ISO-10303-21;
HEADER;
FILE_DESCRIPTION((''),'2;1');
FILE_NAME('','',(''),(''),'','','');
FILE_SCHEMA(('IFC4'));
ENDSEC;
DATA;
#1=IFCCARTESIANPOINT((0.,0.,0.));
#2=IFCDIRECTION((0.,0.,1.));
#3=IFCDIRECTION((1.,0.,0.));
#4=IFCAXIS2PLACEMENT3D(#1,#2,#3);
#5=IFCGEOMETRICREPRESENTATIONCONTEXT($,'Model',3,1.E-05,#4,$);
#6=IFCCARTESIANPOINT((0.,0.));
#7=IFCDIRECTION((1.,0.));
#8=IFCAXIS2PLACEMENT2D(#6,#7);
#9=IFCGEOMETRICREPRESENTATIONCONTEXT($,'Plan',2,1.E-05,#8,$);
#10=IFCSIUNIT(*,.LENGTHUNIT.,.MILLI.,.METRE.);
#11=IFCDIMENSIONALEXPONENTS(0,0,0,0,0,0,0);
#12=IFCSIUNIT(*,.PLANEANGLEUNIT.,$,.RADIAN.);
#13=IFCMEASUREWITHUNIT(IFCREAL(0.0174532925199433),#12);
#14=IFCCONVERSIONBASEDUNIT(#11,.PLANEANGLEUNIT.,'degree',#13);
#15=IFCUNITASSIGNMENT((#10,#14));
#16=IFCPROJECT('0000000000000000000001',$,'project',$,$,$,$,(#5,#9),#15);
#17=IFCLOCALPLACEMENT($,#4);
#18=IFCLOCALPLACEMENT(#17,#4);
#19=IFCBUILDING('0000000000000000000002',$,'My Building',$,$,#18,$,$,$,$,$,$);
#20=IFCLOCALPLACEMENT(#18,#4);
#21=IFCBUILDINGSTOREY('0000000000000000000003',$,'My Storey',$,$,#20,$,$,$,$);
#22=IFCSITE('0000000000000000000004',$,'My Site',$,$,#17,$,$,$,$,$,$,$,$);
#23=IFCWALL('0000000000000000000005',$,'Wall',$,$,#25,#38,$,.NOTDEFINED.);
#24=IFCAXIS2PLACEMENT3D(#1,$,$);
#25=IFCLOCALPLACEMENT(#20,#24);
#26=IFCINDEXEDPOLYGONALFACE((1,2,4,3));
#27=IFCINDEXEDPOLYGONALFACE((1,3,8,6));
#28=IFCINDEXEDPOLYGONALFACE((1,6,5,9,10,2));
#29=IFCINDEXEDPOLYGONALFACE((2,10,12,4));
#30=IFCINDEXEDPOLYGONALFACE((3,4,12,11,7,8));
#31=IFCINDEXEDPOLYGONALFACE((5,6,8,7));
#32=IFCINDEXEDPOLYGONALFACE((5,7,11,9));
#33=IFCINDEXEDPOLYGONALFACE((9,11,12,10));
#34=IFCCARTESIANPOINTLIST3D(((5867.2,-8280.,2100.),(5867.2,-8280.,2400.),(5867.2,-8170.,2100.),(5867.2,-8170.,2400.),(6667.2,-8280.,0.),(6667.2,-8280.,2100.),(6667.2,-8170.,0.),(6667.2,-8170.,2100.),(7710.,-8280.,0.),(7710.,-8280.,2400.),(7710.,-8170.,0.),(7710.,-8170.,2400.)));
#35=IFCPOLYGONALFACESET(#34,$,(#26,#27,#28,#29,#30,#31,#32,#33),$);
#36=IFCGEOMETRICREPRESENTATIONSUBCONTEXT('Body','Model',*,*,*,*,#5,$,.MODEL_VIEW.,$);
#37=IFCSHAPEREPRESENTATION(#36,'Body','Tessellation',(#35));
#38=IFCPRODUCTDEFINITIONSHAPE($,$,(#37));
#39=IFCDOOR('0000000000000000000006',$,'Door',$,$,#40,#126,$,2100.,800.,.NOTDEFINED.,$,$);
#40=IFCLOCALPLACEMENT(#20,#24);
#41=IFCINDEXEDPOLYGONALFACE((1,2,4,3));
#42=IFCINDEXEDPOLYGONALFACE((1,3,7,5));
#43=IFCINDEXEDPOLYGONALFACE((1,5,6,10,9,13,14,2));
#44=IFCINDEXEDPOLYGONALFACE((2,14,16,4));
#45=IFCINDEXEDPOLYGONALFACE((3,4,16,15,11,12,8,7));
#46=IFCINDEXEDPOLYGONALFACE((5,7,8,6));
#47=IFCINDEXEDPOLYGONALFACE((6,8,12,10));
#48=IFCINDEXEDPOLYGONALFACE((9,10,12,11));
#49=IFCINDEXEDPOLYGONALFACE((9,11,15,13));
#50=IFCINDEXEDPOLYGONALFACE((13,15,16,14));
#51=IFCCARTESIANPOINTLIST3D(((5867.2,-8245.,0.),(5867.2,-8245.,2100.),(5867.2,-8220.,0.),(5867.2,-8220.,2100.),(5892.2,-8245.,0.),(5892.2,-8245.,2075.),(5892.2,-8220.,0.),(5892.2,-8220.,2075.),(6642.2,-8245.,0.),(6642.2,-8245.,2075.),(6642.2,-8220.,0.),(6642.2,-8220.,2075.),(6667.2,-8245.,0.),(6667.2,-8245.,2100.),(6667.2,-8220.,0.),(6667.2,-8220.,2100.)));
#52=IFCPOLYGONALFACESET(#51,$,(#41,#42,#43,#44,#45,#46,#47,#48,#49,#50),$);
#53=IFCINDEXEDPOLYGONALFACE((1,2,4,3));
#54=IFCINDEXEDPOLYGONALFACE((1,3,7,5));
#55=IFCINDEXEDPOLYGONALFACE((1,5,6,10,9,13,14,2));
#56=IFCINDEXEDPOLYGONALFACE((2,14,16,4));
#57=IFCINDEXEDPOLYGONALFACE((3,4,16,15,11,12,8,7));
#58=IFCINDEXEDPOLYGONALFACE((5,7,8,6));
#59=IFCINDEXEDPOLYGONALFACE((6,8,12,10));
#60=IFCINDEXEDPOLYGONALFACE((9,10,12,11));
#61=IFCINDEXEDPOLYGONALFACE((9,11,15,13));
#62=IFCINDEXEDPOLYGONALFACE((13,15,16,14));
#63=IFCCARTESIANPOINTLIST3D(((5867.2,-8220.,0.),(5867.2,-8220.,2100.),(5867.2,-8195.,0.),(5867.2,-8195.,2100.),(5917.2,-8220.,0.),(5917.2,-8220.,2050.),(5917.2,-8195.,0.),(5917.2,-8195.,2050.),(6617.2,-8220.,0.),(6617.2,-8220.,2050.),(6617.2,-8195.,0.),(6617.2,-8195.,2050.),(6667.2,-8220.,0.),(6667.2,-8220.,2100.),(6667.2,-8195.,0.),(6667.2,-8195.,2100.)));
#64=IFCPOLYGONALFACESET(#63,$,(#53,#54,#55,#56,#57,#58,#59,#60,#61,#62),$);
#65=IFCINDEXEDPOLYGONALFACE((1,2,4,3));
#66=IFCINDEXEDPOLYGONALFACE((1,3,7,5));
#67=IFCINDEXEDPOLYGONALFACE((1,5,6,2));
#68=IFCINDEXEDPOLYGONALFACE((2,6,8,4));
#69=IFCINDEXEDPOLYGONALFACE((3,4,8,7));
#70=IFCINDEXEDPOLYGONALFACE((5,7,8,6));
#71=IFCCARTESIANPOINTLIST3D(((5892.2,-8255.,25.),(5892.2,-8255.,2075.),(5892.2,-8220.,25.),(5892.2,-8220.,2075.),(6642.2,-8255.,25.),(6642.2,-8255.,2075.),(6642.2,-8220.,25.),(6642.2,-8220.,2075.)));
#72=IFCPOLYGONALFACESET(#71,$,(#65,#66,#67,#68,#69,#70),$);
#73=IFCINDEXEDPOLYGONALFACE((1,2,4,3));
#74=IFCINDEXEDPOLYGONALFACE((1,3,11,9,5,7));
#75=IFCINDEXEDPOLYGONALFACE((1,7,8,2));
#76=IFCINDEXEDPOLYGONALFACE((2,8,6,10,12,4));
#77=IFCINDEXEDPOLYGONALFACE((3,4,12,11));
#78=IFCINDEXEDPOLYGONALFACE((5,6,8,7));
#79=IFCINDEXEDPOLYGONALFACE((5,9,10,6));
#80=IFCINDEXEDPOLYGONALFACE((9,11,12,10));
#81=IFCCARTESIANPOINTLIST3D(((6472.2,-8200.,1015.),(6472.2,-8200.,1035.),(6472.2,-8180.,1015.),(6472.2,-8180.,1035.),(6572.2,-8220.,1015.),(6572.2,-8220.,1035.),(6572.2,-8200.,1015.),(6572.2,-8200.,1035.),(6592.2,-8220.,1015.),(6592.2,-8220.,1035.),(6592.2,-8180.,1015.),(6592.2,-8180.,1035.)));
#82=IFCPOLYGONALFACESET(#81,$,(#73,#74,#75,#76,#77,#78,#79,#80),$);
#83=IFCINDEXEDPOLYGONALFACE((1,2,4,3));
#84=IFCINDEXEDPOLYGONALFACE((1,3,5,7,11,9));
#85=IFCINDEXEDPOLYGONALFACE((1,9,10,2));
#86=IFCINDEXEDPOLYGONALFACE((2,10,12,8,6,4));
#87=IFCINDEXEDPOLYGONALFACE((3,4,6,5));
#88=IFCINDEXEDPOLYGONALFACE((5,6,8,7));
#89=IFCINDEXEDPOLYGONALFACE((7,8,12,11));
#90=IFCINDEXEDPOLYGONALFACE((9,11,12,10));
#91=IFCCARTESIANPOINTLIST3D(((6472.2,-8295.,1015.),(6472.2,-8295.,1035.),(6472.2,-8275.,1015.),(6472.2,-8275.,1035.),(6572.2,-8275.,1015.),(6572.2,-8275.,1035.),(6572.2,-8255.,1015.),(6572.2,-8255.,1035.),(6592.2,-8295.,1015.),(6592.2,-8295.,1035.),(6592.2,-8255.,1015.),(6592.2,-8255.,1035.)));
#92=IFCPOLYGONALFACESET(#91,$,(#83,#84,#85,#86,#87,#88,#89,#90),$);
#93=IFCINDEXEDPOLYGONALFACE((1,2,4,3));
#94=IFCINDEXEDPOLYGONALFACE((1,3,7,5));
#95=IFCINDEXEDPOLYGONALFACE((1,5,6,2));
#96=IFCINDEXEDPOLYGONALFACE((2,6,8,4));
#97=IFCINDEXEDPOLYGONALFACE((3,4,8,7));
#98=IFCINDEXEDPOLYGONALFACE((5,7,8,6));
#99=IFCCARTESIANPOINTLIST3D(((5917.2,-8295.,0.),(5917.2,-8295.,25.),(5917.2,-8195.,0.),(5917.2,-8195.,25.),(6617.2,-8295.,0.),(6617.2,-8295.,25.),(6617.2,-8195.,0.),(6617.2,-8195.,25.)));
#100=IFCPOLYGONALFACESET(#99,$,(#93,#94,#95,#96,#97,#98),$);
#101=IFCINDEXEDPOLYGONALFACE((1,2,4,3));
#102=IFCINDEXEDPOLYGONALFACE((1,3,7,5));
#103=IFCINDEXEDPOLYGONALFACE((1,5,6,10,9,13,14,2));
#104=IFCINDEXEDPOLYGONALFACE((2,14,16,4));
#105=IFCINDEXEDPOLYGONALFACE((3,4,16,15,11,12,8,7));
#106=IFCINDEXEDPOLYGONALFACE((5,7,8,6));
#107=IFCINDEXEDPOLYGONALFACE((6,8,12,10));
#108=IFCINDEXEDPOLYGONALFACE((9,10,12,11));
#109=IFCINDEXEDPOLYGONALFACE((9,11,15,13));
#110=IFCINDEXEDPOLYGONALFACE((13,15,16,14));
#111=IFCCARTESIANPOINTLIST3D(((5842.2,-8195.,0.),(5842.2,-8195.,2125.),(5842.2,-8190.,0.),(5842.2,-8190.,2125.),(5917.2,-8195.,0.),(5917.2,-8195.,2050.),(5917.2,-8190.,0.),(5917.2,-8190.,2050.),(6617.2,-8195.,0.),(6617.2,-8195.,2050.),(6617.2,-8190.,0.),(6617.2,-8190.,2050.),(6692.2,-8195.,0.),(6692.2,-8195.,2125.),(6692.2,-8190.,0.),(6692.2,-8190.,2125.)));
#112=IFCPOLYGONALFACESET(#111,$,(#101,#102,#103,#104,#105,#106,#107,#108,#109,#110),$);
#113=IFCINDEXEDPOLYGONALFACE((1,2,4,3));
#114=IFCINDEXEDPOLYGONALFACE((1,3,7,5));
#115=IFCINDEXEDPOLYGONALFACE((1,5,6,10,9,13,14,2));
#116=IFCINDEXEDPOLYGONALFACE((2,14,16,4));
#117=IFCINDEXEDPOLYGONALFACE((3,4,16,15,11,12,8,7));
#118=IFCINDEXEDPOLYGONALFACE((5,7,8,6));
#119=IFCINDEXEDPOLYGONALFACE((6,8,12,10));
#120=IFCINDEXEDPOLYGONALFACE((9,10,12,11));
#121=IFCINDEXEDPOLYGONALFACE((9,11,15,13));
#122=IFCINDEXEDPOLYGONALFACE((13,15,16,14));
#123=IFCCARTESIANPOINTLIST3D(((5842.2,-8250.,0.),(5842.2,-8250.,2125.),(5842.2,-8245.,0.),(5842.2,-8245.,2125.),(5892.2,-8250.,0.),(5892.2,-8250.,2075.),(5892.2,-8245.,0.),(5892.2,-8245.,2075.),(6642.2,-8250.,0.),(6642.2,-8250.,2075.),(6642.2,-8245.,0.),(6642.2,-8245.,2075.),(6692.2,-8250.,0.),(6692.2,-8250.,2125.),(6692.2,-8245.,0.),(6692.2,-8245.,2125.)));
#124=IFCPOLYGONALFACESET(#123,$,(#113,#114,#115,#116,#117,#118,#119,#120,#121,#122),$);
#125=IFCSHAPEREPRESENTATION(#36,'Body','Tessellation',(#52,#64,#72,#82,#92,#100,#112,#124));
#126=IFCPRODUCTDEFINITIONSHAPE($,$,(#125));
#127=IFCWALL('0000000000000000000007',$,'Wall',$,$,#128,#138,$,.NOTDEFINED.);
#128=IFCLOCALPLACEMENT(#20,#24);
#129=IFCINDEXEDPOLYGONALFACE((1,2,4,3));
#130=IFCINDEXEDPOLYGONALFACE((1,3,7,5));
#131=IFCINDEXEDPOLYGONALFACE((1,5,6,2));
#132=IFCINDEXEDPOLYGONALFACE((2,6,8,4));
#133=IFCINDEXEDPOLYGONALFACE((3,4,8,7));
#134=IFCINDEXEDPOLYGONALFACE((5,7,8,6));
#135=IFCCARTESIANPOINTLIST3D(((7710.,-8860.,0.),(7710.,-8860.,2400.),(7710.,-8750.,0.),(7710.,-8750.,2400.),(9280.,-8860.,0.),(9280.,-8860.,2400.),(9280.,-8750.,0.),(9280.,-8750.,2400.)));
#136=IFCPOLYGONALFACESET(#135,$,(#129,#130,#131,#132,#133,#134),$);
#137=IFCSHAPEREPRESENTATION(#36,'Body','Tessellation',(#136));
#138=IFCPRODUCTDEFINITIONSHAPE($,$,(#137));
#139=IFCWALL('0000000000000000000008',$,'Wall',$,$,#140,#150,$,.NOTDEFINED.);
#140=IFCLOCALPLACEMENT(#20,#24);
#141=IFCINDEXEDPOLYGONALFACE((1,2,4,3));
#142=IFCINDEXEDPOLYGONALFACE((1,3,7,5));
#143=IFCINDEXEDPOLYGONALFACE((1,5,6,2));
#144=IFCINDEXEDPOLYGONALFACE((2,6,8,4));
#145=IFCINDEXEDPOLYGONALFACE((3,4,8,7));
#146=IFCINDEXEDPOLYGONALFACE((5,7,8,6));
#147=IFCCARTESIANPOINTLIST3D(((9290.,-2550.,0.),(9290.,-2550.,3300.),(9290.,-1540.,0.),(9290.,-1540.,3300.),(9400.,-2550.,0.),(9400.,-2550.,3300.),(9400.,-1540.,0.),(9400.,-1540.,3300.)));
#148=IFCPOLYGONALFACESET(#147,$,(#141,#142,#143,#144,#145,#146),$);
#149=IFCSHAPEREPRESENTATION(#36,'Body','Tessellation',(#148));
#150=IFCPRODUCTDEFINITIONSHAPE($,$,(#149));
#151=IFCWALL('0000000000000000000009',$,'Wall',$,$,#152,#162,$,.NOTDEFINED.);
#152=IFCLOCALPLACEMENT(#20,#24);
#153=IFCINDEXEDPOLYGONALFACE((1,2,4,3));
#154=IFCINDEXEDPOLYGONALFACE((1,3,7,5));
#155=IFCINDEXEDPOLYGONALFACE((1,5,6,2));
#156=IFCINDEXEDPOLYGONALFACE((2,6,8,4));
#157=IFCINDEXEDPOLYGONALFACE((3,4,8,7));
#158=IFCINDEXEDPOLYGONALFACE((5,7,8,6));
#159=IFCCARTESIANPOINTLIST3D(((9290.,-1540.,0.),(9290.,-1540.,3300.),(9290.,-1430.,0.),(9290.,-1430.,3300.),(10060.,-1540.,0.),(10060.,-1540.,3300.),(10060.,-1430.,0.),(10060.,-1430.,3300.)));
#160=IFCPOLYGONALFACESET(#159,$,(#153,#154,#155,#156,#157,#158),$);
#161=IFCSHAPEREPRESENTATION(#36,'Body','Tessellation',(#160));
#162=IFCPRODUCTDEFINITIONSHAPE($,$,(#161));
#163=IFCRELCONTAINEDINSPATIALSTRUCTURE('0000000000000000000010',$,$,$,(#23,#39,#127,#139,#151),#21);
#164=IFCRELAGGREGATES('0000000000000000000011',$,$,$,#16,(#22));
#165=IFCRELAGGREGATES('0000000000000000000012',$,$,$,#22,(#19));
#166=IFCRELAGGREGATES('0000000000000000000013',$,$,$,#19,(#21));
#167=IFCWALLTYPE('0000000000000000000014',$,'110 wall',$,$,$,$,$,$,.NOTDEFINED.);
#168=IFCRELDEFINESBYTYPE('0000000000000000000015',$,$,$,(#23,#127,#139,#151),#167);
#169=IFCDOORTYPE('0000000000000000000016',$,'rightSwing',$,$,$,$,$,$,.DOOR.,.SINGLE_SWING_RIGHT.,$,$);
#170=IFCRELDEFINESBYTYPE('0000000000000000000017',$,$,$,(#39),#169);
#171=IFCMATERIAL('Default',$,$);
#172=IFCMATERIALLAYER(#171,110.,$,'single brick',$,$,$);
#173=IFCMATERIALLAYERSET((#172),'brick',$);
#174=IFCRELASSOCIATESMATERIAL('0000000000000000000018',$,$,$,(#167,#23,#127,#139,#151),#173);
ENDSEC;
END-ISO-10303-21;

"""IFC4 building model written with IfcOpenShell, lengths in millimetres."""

from ifc_helpers import new_model, entity, si_unit, converted_unit, frame, origin_with_axes, origin_2d_with_axis, place, context, subcontext, project, spatial, line, indexed_curve, outline, extrude, shape, source, transform, mapped, material, layer, layer_set, layer_usage, type_object, type_shapes, element, fill, save


model = new_model("IFC4")

# Units and contexts
model_context = context("Model", 3, precision=1e-05, world=origin_with_axes())
plan_context = context("Plan", 2, precision=1e-05, world=origin_2d_with_axis())
body_context_1 = subcontext(model_context, "Body", "Model", "MODEL_VIEW")
body_context_2 = subcontext(plan_context, "Body", "Plan", "PLAN_VIEW")
ifc_project = project(units=[si_unit("LENGTHUNIT", "METRE", prefix="MILLI"), converted_unit("PLANEANGLEUNIT", "degree", entity("IfcReal", 0.0174532925199433), si_unit("PLANEANGLEUNIT", "RADIAN"), dimensions=[0, 0, 0, 0, 0, 0, 0])], contexts=[model_context, plan_context])

# Site, building, storey
site_placement = place(None, origin_with_axes())
site = spatial("IfcSite", under=ifc_project, at=site_placement, Name="My Site")
building_placement = place(site_placement, origin_with_axes())
building = spatial("IfcBuilding", under=site, at=building_placement, Name="My Building")
storey_placement = place(building_placement, origin_with_axes())
storey = spatial("IfcBuildingStorey", under=building, at=storey_placement, Name="My Storey")

# Shared definitions
ifc_material_1 = material(Name="Default")
ifc_layer_1 = layer(ifc_material_1, 110.0, Name="single brick")
ifc_layer_set_1 = layer_set([ifc_layer_1], Name="brick")
wall_type_1 = type_object("IfcWallType", Name="110 wall", PredefinedType="NOTDEFINED", material=ifc_layer_set_1)

# Wall, opening, door
ifc_layer_usage_1 = layer_usage(ifc_layer_set_1, "AXIS2", "POSITIVE", 0.0)
wall_1_placement = place(storey_placement, frame((5867.2, -8280.0, 0.0), z_axis=(0.0, 0.0, 1.0), x_axis=(1.0, -0.000001, 0.0)))
wall_1 = element("IfcWall", 1, at=wall_1_placement, inside=storey, type_object=wall_type_1, material=ifc_layer_usage_1, Name="Wall", PredefinedType="NOTDEFINED", context=body_context_1, shape_type="SweptSolid", body=[
    extrude(outline(indexed_curve([(0.0, 0.0), (0.0, 110.0), (1842.8, 110.0), (1842.8, 0.0), (0.0, 0.0)], self_intersect=False)), origin_with_axes(), (0.0, 0.0, 1.0), 2400.0),
])
shared_shape_1 = source(origin_with_axes(), body_context_1, "Body", "SweptSolid", [
    extrude(outline(indexed_curve([(0.0, 0.0, 0.0), (800.0, 0.0, 0.0), (800.0, 0.0, 2100.0), (0.0, 0.0, 2100.0)], segments=[line(1, 2), line(2, 3), line(3, 4), line(4, 1)])), frame((0.0, -100.0, 0.0), z_axis=(0.0, 0.0, 1.0), x_axis=(1.0, 0.0, 0.0)), (0.0, 1.0, 0.0), 310.0),
])
opening_1_placement = place(wall_1_placement, frame((800.0, 85.0, 0.0), z_axis=(0.0, 0.0, 1.0), x_axis=(-1.0, 0.0, 0.0)))
opening_1 = element("IfcOpeningElement", 2, at=opening_1_placement, cuts=wall_1, PredefinedType="OPENING", context=body_context_1, shape_type="MappedRepresentation", body=[
    mapped(shared_shape_1, transform((0.0, 0.0, 0.0), x_axis=(1.0, 0.0, 0.0), y_axis=(0.0, 1.0, 0.0), z_axis=(0.0, 0.0, 1.0), scale=1.0)),
])
door_type_1 = type_object("IfcDoorType", Name="rightSwing", OperationType="SINGLE_SWING_RIGHT", PredefinedType="DOOR")
shared_shape_2 = source(origin_with_axes(), body_context_1, "Body", "SweptSolid", [
    extrude(outline(indexed_curve([(0.0, 0.0, 0.0), (0.0, 0.0, 2100.0), (800.0, 0.0, 2100.0), (800.0, 0.0, 0.0), (775.0, 0.0, 0.0), (775.0, 0.0, 2075.0), (25.0, 0.0, 2075.0), (25.0, 0.0, 0.0)], segments=[line(1, 2), line(2, 3), line(3, 4), line(4, 5), line(5, 6), line(6, 7), line(7, 8), line(8, 1)])), frame((0.0, 25.0, 0.0), z_axis=(0.0, 0.0, 1.0), x_axis=(1.0, 0.0, 0.0)), (0.0, 1.0, 0.0), 25.0),
    extrude(outline(indexed_curve([(0.0, 0.0, 0.0), (0.0, 0.0, 2100.0), (800.0, 0.0, 2100.0), (800.0, 0.0, 0.0), (750.0, 0.0, 0.0), (750.0, 0.0, 2050.0), (50.0, 0.0, 2050.0), (50.0, 0.0, 0.0)], segments=[line(1, 2), line(2, 3), line(3, 4), line(4, 5), line(5, 6), line(6, 7), line(7, 8), line(8, 1)])), origin_with_axes(), (0.0, 1.0, 0.0), 25.0),
    extrude(outline(indexed_curve([(0.0, 0.0), (750.0, 0.0), (750.0, 35.0), (0.0, 35.0)], segments=[line(1, 2), line(2, 3), line(3, 4), line(4, 1)])), frame((25.0, 25.0, 25.0), z_axis=(0.0, 0.0, 1.0), x_axis=(1.0, 0.0, 0.0)), (0.0, 0.0, 1.0), 2050.0),
    extrude(outline(indexed_curve([(0.0, 0.0), (0.0, -40.0), (120.0, -40.0), (120.0, -20.0), (20.0, -20.0), (20.0, 0.0)], segments=[line(1, 2), line(2, 3), line(3, 4), line(4, 5), line(5, 6), line(6, 1)])), frame((75.0, 25.0, 1015.0), z_axis=(0.0, 0.0, 1.0), x_axis=(1.0, 0.0, 0.0)), (0.0, 0.0, 1.0), 20.0),
    extrude(outline(indexed_curve([(0.0, 0.0), (0.0, 40.0), (120.0, 40.0), (120.0, 20.0), (20.0, 20.0), (20.0, 0.0)], segments=[line(1, 2), line(2, 3), line(3, 4), line(4, 5), line(5, 6), line(6, 1)])), frame((75.0, 60.0, 1015.0), z_axis=(0.0, 0.0, 1.0), x_axis=(1.0, 0.0, 0.0)), (0.0, 0.0, 1.0), 20.0),
    extrude(outline(indexed_curve([(0.0, 0.0), (700.0, 0.0), (700.0, 100.0), (0.0, 100.0)], segments=[line(1, 2), line(2, 3), line(3, 4), line(4, 1)])), frame((50.0, 0.0, 0.0), z_axis=(0.0, 0.0, 1.0), x_axis=(1.0, 0.0, 0.0)), (0.0, 0.0, 1.0), 25.0),
    extrude(outline(indexed_curve([(0.0, 0.0, 0.0), (0.0, 0.0, 2125.0), (850.0, 0.0, 2125.0), (850.0, 0.0, 0.0), (775.0, 0.0, 0.0), (775.0, 0.0, 2050.0), (75.0, 0.0, 2050.0), (75.0, 0.0, 0.0)], segments=[line(1, 2), line(2, 3), line(3, 4), line(4, 5), line(5, 6), line(6, 7), line(7, 8), line(8, 1)])), frame((-25.0, -5.0, 0.0), z_axis=(0.0, 0.0, 1.0), x_axis=(1.0, 0.0, 0.0)), (0.0, 1.0, 0.0), 5.0),
    extrude(outline(indexed_curve([(0.0, 0.0, 0.0), (0.0, 0.0, 2125.0), (850.0, 0.0, 2125.0), (850.0, 0.0, 0.0), (800.0, 0.0, 0.0), (800.0, 0.0, 2075.0), (50.0, 0.0, 2075.0), (50.0, 0.0, 0.0)], segments=[line(1, 2), line(2, 3), line(3, 4), line(4, 5), line(5, 6), line(6, 7), line(7, 8), line(8, 1)])), frame((-25.0, 50.0, 0.0), z_axis=(0.0, 0.0, 1.0), x_axis=(1.0, 0.0, 0.0)), (0.0, 1.0, 0.0), 5.0),
])
shared_shape_3 = source(origin_with_axes(), body_context_2, "Body", "Curve2D", [
    entity("IfcIndexedPolyCurve", entity("IfcCartesianPointList2D", [[0.0, 0.0], [0.0, 50.0], [25.0, 50.0], [25.0, 25.0], [50.0, 25.0], [50.0, 0.0]]), [entity("IfcLineIndex", [1, 2]), entity("IfcLineIndex", [2, 3]), entity("IfcLineIndex", [3, 4]), entity("IfcLineIndex", [4, 5]), entity("IfcLineIndex", [5, 6]), entity("IfcLineIndex", [6, 1])]),
    entity("IfcIndexedPolyCurve", entity("IfcCartesianPointList2D", [[800.0, 0.0], [800.0, 50.0], [775.0, 50.0], [775.0, 25.0], [750.0, 25.0], [750.0, 0.0]]), [entity("IfcLineIndex", [1, 2]), entity("IfcLineIndex", [2, 3]), entity("IfcLineIndex", [3, 4]), entity("IfcLineIndex", [4, 5]), entity("IfcLineIndex", [5, 6]), entity("IfcLineIndex", [6, 1])]),
    entity("IfcTrimmedCurve", entity("IfcEllipse", entity("IfcAxis2Placement2D", entity("IfcCartesianPoint", [740.0, 50.0]), entity("IfcDirection", [1.0, 0.0])), 715.0, 750.0), [entity("IfcCartesianPoint", [740.0, 800.0])], [entity("IfcCartesianPoint", [25.0, 50.0])], True, "CARTESIAN"),
    entity("IfcIndexedPolyCurve", entity("IfcCartesianPointList2D", [[775.0, 50.0], [740.0, 50.0], [740.0, 800.0], [775.0, 800.0]]), [entity("IfcLineIndex", [1, 2]), entity("IfcLineIndex", [2, 3]), entity("IfcLineIndex", [3, 4]), entity("IfcLineIndex", [4, 1])]),
])
type_shapes(door_type_1, [shared_shape_2, shared_shape_3])
door_1_placement = place(storey_placement, frame((6667.2, -8195.0, 0.0), z_axis=(0.0, 0.0, 1.0), x_axis=(-1.0, 0.000001, 0.0)))
door_1 = element("IfcDoor", 3, at=door_1_placement, inside=storey, type_object=door_type_1, Name="Door", OverallHeight=2100.0, OverallWidth=800.0, PredefinedType="NOTDEFINED", shapes=[
    shape(body_context_1, "Body", "MappedRepresentation", [mapped(shared_shape_2, transform((0.0, 0.0, 0.0), x_axis=(1.0, 0.0, 0.0), y_axis=(0.0, 1.0, 0.0), z_axis=(0.0, 0.0, 1.0), scale=1.0))]),
    shape(body_context_2, "Body", "MappedRepresentation", [mapped(shared_shape_3, transform((0.0, 0.0, 0.0), x_axis=(1.0, 0.0, 0.0), y_axis=(0.0, 1.0, 0.0), z_axis=(0.0, 0.0, 1.0), scale=1.0))]),
])
fill(opening_1, door_1)

# Walls
ifc_layer_usage_2 = layer_usage(ifc_layer_set_1, "AXIS2", "POSITIVE", 0.0)
wall_2_placement = place(storey_placement, frame((9280.0, -8750.0, 0.0), z_axis=(0.0, 0.0, 1.0), x_axis=(-1.0, 0.000001, 0.0)))
element("IfcWall", 4, at=wall_2_placement, inside=storey, type_object=wall_type_1, material=ifc_layer_usage_2, Name="Wall", PredefinedType="NOTDEFINED", context=body_context_1, shape_type="SweptSolid", body=[
    extrude(outline(indexed_curve([(0.0, 0.0), (0.0, 110.0), (1570.0, 110.0), (1570.0, 0.0), (0.0, 0.0)], self_intersect=False)), origin_with_axes(), (0.0, 0.0, 1.0), 2400.0),
])
ifc_layer_usage_3 = layer_usage(ifc_layer_set_1, "AXIS2", "POSITIVE", 0.0)
wall_3_placement = place(storey_placement, frame((9400.0, -2550.0, 0.0), z_axis=(0.0, 0.0, 1.0), x_axis=(0.000001, 1.0, 0.0)))
element("IfcWall", 5, at=wall_3_placement, inside=storey, type_object=wall_type_1, material=ifc_layer_usage_3, Name="Wall", PredefinedType="NOTDEFINED", context=body_context_1, shape_type="SweptSolid", body=[
    extrude(outline(indexed_curve([(0.0, 0.0), (0.0, 110.0), (1010.0, 110.0), (1010.0, 0.0), (0.0, 0.0)], self_intersect=False)), origin_with_axes(), (0.0, 0.0, 1.0), 3300.0),
])
ifc_layer_usage_4 = layer_usage(ifc_layer_set_1, "AXIS2", "POSITIVE", 0.0)
wall_4_placement = place(storey_placement, frame((9290.0, -1540.0, 0.0), z_axis=(0.0, 0.0, 1.0), x_axis=(1.0, -0.000001, 0.0)))
element("IfcWall", 6, at=wall_4_placement, inside=storey, type_object=wall_type_1, material=ifc_layer_usage_4, Name="Wall", PredefinedType="NOTDEFINED", context=body_context_1, shape_type="SweptSolid", body=[
    extrude(outline(indexed_curve([(0.0, 0.0), (0.0, 110.0), (770.0, 110.0), (770.0, 0.0), (0.0, 0.0)], self_intersect=False)), origin_with_axes(), (0.0, 0.0, 1.0), 3300.0),
])

save(model, "model.ifc")
